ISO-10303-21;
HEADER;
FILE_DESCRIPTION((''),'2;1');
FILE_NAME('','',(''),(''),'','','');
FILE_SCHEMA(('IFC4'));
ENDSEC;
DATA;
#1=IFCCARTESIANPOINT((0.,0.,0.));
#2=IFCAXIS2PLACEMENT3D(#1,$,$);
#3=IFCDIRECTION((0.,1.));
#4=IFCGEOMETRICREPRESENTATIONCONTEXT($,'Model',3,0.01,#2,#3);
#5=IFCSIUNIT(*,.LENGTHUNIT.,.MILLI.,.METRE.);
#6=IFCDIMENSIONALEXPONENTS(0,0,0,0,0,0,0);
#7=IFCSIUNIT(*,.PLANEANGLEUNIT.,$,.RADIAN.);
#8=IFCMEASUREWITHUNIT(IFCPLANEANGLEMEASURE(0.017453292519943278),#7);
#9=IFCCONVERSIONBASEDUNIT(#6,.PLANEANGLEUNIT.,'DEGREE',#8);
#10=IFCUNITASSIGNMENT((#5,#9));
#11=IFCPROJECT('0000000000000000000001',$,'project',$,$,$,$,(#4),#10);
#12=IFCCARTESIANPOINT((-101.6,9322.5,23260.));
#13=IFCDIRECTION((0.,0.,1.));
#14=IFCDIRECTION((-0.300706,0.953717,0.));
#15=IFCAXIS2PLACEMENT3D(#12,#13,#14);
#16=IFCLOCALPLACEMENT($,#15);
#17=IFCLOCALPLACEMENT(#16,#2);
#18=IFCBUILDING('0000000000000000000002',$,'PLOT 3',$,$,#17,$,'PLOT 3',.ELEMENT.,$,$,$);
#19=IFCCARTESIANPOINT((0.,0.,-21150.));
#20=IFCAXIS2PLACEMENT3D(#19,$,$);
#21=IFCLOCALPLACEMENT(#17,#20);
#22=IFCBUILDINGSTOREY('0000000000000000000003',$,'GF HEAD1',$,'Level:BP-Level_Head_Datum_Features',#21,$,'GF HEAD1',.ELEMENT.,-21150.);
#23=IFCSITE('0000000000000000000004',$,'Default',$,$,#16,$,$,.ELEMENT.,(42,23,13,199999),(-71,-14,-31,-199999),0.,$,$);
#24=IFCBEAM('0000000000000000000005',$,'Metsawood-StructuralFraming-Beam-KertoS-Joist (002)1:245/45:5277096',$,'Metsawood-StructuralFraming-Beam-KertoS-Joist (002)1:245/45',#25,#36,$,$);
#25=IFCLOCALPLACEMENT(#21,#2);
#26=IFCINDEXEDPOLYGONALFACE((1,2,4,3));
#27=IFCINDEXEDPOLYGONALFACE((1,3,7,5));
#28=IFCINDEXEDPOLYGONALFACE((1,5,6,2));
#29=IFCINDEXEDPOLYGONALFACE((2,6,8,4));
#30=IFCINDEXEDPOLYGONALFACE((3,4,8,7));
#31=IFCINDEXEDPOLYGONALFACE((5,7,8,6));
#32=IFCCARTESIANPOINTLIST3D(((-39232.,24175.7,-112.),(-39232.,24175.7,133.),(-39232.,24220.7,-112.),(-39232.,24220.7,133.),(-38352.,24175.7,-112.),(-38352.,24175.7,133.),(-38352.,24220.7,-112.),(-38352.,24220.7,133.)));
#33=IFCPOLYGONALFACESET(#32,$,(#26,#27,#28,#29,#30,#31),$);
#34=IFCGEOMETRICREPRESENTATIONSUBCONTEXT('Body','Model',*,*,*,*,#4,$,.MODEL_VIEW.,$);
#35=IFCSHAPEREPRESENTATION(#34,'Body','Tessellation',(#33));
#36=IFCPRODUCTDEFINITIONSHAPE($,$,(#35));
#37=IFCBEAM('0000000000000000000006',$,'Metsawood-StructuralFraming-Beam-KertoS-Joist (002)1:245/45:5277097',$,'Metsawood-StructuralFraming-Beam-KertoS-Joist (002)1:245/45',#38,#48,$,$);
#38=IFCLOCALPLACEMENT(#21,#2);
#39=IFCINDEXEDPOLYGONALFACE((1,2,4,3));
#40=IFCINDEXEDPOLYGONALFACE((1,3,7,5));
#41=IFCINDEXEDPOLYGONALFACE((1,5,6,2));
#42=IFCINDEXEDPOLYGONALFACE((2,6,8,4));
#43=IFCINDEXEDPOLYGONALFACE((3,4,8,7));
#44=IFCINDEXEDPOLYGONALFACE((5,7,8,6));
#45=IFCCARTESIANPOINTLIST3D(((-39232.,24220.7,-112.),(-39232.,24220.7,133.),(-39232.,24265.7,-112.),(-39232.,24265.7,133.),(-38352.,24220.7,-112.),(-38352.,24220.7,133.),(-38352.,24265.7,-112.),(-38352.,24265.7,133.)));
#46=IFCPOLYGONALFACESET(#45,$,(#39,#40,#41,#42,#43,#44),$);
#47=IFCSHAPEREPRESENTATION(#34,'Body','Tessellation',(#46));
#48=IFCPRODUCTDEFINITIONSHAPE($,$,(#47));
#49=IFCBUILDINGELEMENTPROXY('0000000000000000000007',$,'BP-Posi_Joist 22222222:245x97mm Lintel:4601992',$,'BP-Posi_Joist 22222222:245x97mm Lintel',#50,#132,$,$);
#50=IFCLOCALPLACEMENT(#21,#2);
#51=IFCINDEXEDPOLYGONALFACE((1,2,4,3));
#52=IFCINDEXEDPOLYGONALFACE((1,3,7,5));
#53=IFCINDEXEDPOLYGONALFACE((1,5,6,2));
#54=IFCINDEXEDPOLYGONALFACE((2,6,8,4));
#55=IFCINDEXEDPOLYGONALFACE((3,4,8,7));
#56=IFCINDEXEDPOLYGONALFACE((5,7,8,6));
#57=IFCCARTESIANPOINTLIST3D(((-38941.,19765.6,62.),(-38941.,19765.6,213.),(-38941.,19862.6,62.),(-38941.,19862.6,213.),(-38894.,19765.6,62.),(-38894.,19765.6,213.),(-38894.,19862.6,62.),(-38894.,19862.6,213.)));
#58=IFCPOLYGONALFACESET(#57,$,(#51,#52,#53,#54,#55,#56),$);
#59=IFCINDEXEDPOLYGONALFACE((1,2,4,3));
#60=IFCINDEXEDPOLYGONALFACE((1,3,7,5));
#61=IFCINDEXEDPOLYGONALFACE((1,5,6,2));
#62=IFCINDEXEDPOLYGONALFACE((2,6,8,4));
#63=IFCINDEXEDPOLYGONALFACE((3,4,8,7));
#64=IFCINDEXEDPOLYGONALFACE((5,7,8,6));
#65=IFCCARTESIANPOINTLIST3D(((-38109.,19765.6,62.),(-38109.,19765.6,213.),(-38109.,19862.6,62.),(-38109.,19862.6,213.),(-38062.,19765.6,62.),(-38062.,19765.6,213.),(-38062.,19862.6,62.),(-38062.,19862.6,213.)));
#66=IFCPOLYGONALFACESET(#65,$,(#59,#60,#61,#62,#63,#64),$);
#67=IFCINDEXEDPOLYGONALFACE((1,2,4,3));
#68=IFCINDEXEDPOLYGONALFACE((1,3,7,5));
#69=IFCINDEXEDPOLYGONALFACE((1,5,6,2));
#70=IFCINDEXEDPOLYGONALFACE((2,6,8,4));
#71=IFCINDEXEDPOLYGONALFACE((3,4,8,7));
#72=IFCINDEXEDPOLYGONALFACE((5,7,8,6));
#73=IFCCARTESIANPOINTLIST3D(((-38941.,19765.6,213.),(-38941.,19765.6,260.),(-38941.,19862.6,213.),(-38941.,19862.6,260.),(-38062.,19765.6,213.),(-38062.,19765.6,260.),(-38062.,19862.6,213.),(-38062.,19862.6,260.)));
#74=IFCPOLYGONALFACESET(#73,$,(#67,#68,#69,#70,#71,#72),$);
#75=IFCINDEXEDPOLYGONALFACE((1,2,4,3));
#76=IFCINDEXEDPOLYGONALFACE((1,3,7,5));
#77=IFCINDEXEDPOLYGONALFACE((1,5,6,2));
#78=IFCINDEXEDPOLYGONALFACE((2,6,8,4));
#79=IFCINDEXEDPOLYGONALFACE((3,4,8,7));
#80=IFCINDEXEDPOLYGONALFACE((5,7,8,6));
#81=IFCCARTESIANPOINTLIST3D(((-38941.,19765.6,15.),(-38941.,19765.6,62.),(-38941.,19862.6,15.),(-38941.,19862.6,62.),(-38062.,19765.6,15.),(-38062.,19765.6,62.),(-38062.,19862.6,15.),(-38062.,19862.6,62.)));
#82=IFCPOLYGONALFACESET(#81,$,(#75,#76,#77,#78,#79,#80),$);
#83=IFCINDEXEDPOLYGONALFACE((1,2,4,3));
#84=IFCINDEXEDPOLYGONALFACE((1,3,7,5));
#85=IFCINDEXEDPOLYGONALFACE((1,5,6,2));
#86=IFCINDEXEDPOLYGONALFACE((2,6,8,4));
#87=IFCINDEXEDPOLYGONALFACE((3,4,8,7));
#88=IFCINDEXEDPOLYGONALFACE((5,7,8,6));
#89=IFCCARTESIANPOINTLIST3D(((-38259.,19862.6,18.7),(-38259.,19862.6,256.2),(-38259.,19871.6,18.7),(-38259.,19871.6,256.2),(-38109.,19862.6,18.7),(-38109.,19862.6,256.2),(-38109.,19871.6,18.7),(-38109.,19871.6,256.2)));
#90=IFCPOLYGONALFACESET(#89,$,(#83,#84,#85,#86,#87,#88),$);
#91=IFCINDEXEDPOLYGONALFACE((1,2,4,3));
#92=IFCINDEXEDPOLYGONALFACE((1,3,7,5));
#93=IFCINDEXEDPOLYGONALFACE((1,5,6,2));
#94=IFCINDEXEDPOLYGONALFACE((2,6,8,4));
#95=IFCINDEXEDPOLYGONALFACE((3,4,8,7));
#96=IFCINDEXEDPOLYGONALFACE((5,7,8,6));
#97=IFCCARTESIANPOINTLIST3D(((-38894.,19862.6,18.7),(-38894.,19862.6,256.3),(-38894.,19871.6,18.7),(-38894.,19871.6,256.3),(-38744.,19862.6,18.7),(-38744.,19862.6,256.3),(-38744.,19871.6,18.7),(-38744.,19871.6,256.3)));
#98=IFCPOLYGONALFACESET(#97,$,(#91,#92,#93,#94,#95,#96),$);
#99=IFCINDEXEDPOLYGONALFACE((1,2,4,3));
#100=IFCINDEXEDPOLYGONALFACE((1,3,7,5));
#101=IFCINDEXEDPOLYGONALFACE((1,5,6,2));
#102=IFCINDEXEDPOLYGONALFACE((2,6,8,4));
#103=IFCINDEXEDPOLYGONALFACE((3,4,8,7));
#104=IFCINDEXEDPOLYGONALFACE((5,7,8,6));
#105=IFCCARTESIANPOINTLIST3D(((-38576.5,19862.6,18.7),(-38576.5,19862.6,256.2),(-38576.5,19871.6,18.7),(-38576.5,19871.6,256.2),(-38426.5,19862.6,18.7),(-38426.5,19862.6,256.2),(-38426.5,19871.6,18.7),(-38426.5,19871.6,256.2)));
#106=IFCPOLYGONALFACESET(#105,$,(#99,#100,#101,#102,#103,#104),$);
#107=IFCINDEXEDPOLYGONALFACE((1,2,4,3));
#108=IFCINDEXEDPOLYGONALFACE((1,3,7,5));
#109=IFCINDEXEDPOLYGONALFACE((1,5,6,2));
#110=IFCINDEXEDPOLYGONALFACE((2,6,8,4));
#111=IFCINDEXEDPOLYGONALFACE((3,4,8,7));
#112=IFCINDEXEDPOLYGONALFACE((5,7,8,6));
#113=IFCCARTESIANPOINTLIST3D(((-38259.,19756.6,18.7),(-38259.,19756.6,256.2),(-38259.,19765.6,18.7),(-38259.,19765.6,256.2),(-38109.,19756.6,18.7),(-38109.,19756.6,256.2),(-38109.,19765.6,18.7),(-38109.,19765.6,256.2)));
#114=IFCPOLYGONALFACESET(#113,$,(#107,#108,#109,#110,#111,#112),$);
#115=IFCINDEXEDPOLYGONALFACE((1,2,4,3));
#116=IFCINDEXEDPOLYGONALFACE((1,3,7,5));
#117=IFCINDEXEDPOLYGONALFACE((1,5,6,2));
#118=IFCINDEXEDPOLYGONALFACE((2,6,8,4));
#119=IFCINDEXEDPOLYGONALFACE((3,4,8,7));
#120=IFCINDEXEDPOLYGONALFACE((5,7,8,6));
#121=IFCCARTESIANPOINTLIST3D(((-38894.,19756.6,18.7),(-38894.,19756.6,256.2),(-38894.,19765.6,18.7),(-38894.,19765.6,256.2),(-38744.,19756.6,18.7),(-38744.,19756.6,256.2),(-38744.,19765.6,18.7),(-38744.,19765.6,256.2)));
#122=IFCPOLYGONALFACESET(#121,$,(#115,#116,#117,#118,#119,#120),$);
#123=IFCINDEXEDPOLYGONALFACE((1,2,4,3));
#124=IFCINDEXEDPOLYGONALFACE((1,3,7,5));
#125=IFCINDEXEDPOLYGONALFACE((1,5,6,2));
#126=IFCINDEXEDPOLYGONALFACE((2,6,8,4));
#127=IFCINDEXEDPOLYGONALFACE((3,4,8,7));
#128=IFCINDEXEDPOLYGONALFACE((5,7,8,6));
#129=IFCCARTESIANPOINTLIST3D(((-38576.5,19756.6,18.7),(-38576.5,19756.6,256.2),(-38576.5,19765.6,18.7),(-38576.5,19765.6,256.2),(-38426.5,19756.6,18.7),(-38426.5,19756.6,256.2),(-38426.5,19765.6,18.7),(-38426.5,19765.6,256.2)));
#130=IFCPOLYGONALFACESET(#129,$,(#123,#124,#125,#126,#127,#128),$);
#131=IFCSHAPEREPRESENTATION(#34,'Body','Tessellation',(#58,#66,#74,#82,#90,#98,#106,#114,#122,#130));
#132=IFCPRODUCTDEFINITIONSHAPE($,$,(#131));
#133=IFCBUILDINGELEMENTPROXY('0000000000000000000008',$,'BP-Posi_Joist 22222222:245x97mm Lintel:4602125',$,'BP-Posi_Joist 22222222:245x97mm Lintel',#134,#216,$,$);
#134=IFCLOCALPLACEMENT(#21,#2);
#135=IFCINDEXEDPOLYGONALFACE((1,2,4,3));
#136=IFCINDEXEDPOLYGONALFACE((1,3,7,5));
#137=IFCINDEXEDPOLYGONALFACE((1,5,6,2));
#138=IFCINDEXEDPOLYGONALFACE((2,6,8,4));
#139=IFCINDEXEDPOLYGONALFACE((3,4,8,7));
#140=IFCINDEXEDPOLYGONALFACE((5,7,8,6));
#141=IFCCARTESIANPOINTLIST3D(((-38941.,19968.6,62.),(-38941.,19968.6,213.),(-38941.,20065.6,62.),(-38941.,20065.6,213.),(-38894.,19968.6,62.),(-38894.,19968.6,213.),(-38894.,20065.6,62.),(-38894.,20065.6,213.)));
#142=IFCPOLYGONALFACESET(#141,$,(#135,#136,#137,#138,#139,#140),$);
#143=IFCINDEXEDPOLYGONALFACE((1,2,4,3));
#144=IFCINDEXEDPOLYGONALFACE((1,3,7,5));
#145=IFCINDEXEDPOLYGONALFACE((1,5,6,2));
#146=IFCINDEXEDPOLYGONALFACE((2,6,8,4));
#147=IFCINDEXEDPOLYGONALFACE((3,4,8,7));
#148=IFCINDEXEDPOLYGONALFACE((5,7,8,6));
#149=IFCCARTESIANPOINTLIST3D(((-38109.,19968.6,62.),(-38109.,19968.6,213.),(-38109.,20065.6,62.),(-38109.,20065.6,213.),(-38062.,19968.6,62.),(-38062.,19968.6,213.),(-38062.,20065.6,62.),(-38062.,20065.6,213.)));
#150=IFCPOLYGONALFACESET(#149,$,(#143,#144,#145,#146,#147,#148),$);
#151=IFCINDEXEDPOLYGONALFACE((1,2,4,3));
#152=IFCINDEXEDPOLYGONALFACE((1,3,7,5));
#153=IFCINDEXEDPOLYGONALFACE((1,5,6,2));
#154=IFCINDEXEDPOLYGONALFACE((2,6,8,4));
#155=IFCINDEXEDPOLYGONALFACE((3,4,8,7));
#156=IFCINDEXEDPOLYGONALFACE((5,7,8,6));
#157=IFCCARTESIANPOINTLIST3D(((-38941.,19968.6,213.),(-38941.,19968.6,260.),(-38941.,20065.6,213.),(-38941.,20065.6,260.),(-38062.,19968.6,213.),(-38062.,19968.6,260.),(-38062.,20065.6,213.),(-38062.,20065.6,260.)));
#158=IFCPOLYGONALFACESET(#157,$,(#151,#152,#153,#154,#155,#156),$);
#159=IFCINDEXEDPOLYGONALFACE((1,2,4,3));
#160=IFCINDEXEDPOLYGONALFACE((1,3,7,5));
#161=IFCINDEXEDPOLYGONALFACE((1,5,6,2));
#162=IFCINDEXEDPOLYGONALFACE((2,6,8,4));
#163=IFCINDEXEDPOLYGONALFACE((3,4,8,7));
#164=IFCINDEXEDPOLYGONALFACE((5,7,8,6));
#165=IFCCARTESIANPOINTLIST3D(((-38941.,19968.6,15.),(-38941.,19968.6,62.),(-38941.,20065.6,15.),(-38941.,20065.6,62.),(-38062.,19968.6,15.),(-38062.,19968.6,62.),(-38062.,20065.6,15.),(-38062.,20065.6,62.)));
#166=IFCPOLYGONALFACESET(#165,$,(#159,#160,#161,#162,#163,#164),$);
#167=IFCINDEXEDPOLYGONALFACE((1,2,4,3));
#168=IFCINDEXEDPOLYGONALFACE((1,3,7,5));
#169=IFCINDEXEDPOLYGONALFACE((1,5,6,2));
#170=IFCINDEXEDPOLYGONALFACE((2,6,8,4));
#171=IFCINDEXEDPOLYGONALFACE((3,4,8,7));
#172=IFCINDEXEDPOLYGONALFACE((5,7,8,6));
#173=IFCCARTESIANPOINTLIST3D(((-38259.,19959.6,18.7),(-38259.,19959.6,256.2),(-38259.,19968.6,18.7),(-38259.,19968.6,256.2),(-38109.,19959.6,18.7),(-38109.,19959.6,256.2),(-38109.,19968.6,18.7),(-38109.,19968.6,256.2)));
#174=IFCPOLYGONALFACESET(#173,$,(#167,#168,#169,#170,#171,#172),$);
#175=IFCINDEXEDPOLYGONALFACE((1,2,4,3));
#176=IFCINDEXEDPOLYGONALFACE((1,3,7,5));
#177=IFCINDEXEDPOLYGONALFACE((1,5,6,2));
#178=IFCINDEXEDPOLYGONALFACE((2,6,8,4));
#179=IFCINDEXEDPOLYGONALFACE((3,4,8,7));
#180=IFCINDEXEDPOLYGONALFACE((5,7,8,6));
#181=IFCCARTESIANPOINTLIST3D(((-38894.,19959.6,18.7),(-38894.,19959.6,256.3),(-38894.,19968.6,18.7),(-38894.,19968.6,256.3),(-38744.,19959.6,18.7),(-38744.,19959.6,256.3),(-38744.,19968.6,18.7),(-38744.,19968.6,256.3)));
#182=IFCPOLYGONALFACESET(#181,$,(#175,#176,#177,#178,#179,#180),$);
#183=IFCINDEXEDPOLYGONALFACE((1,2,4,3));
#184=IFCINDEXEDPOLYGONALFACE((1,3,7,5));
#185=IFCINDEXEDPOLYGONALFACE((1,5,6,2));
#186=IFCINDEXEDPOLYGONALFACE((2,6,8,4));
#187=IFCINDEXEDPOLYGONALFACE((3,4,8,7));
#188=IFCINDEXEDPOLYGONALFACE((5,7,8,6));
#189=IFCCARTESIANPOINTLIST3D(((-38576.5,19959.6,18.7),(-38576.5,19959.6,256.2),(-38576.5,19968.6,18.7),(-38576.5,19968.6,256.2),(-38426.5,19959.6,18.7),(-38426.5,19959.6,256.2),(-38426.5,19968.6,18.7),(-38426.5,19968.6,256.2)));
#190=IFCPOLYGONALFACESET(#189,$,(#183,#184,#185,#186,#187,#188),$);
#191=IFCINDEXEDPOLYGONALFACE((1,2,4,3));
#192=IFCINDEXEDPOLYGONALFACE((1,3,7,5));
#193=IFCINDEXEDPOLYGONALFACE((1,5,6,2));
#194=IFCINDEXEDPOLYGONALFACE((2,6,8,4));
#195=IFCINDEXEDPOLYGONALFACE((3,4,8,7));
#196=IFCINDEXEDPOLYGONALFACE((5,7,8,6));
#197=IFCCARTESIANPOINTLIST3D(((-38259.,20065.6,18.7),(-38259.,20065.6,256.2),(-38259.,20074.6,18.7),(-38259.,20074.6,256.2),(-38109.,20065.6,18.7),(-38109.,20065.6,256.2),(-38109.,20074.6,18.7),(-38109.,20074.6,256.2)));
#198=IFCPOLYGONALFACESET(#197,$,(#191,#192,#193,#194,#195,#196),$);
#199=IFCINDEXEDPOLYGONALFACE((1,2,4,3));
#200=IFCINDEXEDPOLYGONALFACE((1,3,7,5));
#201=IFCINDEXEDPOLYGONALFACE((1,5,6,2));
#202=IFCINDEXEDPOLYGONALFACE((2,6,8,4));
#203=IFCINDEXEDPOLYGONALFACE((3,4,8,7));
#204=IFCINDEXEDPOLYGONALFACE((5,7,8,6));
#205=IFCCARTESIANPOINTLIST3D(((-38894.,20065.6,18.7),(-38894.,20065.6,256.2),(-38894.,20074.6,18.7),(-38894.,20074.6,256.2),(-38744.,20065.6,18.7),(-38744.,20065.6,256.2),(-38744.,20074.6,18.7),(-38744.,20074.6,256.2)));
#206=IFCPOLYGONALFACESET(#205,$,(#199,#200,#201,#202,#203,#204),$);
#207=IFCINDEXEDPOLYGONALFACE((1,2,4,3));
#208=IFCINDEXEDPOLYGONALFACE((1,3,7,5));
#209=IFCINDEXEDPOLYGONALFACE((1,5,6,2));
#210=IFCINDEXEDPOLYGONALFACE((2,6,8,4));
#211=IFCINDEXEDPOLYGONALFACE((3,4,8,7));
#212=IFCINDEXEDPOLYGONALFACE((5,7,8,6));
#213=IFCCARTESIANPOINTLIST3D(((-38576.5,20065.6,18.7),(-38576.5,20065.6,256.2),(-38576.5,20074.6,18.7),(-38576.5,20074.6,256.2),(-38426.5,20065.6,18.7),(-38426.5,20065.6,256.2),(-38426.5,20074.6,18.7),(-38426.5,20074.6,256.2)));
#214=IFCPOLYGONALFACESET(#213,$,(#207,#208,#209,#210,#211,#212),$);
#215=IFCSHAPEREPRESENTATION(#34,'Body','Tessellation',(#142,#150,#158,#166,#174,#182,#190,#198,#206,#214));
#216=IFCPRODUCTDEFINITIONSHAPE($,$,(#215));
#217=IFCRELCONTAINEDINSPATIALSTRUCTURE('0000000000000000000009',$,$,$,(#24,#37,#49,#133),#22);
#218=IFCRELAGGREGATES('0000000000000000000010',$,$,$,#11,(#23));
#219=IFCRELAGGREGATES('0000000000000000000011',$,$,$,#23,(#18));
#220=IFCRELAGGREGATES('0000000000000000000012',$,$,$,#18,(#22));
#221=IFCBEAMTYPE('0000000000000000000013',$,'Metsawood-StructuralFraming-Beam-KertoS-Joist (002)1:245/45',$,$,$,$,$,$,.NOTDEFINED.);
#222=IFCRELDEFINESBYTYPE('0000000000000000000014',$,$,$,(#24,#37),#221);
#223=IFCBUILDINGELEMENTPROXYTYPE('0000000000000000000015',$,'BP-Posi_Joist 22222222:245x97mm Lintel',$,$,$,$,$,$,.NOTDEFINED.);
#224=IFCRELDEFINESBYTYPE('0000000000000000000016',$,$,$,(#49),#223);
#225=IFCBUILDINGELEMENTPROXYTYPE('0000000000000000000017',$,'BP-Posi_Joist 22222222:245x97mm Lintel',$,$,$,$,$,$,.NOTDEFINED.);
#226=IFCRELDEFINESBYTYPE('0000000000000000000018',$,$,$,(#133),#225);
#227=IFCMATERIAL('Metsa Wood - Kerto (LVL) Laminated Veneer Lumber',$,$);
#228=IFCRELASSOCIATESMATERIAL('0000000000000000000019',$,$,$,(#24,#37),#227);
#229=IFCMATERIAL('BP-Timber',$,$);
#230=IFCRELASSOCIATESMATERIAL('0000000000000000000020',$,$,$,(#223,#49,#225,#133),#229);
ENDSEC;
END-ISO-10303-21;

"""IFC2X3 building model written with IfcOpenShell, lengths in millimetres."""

from ifc_helpers import new_model, entity, si_unit, converted_unit, direction, frame, frame_2d, origin, origin_2d_with_axis, place, context, subcontext, project, spatial, rectangle, extrude, source, transform, mapped, material, type_object, type_shapes, element, save


model = new_model("IFC2X3")

# Units and contexts
model_context = context("Model", 3, precision=0.01, world=origin(), true_north=direction((0.0, 1.0)))
body_context = subcontext(model_context, "Body", "Model", "MODEL_VIEW")
ifc_project = project(units=[si_unit("LENGTHUNIT", "METRE", prefix="MILLI"), converted_unit("PLANEANGLEUNIT", "DEGREE", entity("IfcPlaneAngleMeasure", 0.017453292519943278), si_unit("PLANEANGLEUNIT", "RADIAN"), dimensions=[0, 0, 0, 0, 0, 0, 0])], contexts=[model_context])

# Site, building, storey
site_placement = place(None, frame((-101.6, 9322.5, 23260.0), z_axis=(0.0, 0.0, 1.0), x_axis=(-0.300706, 0.953717, 0.0)))
site = spatial("IfcSite", under=ifc_project, at=site_placement, Name="Default", CompositionType="ELEMENT", RefLatitude=(42, 23, 13, 199999), RefLongitude=(-71, -14, -31, -199999), RefElevation=0.0)
building_placement = place(site_placement, origin())
building = spatial("IfcBuilding", under=site, at=building_placement, Name="PLOT 3", LongName="PLOT 3", CompositionType="ELEMENT")
storey_placement = place(building_placement, frame((0.0, 0.0, -21150.0)))
storey = spatial("IfcBuildingStorey", under=building, at=storey_placement, Name="GF HEAD1", ObjectType="Level:BP-Level_Head_Datum_Features", LongName="GF HEAD1", CompositionType="ELEMENT", Elevation=-21150.0)

# Shared definitions
ifc_material_1 = material(Name="BP-Timber")

# Beams
ifc_material_2 = material(Name="Metsa Wood - Kerto (LVL) Laminated Veneer Lumber")
beam_type_1 = type_object("IfcBeamType", Name="Metsawood-StructuralFraming-Beam-KertoS-Joist (002)1:245/45", PredefinedType="NOTDEFINED")
beam_1_placement = place(storey_placement, frame((-39232.0, 24198.2, 10.5)))
element("IfcBeam", 1, at=beam_1_placement, inside=storey, type_object=beam_type_1, material=ifc_material_2, Name="Metsawood-StructuralFraming-Beam-KertoS-Joist (002)1:245/45:5277096", ObjectType="Metsawood-StructuralFraming-Beam-KertoS-Joist (002)1:245/45", context=body_context, shape_type="SweptSolid", body=[
    extrude(rectangle(XDim=245.0, YDim=45.0, at=frame_2d((0.0, 0.0), x_axis=(1.0, 0.0))), frame((0.0, 0.0, 0.0), z_axis=(1.0, 0.0, 0.0), x_axis=(0.0, 0.0, -1.0)), (0.0, 0.0, 1.0), 880.0),
])
beam_2_placement = place(storey_placement, frame((-39232.0, 24243.2, 10.5)))
element("IfcBeam", 2, at=beam_2_placement, inside=storey, type_object=beam_type_1, material=ifc_material_2, Name="Metsawood-StructuralFraming-Beam-KertoS-Joist (002)1:245/45:5277097", ObjectType="Metsawood-StructuralFraming-Beam-KertoS-Joist (002)1:245/45", context=body_context, shape_type="SweptSolid", body=[
    extrude(rectangle(XDim=245.0, YDim=45.0, at=frame_2d((0.0, 0.0), x_axis=(1.0, 0.0))), frame((0.0, 0.0, 0.0), z_axis=(1.0, 0.0, 0.0), x_axis=(0.0, 0.0, -1.0)), (0.0, 0.0, 1.0), 880.0),
])

# Building element proxies
building_element_proxy_type_1 = type_object("IfcBuildingElementProxyType", Name="BP-Posi_Joist 22222222:245x97mm Lintel", PredefinedType="NOTDEFINED", material=ifc_material_1)
shared_shape_1 = source(origin(), body_context, "Body", "SweptSolid", [
    extrude(rectangle(XDim=47.0, YDim=97.0, at=origin_2d_with_axis()), frame((320.4, 0.0, -198.0), z_axis=(0.0, 0.0, 1.0), x_axis=(-1.0, 0.0, 0.0)), (0.0, 0.0, 1.0), 151.0),
    extrude(rectangle(XDim=47.0, YDim=97.0, at=frame_2d((0.0, 0.0), x_axis=(1.0, 0.0))), frame((1152.4, 0.0, -198.0), z_axis=(0.0, 0.0, 1.0), x_axis=(-1.0, 0.0, 0.0)), (0.0, 0.0, 1.0), 151.0),
    extrude(rectangle(XDim=97.0, YDim=879.0, at=frame_2d((0.0, 0.0), x_axis=(1.0, 0.0))), frame((736.4, 0.0, -47.0), z_axis=(0.0, 0.0, 1.0), x_axis=(0.0, -1.0, 0.0)), (0.0, 0.0, 1.0), 47.0),
    extrude(rectangle(XDim=97.0, YDim=879.0, at=frame_2d((0.0, 0.0), x_axis=(1.0, 0.0))), frame((736.4, 0.0, -245.0), z_axis=(0.0, 0.0, 1.0), x_axis=(0.0, -1.0, 0.0)), (0.0, 0.0, 1.0), 47.0),
    extrude(rectangle(XDim=9.0, YDim=150.0, at=origin_2d_with_axis()), frame((1053.9, 53.0, -241.3), z_axis=(0.0, 0.0, 1.0), x_axis=(0.0, -1.0, 0.0)), (0.0, 0.0, 1.0), 237.5),
    extrude(rectangle(XDim=9.0, YDim=150.0, at=frame_2d((0.0, 0.0), x_axis=(1.0, 0.0))), frame((418.9, 53.0, -241.3), z_axis=(0.0, 0.0, 1.0), x_axis=(0.0, 1.0, 0.0)), (0.0, 0.0, 1.0), 237.5),
    extrude(rectangle(XDim=9.0, YDim=150.0, at=origin_2d_with_axis()), frame((736.4, 53.0, -241.3), z_axis=(0.0, 0.0, 1.0), x_axis=(0.0, -1.0, 0.0)), (0.0, 0.0, 1.0), 237.5),
    extrude(rectangle(XDim=9.0, YDim=150.0, at=origin_2d_with_axis()), frame((1053.9, -53.0, -241.3), z_axis=(0.0, 0.0, 1.0), x_axis=(0.0, -1.0, 0.0)), (0.0, 0.0, 1.0), 237.5),
    extrude(rectangle(XDim=9.0, YDim=150.0, at=frame_2d((0.0, 0.0), x_axis=(1.0, 0.0))), frame((418.9, -53.0, -241.3), z_axis=(0.0, 0.0, 1.0), x_axis=(0.0, 1.0, 0.0)), (0.0, 0.0, 1.0), 237.5),
    extrude(rectangle(XDim=9.0, YDim=150.0, at=origin_2d_with_axis()), frame((736.4, -53.0, -241.3), z_axis=(0.0, 0.0, 1.0), x_axis=(0.0, -1.0, 0.0)), (0.0, 0.0, 1.0), 237.5),
])
type_shapes(building_element_proxy_type_1, [shared_shape_1])
proxy_1_placement = place(storey_placement, frame((-39237.9, 19814.1, 260.0)))
element("IfcBuildingElementProxy", 3, at=proxy_1_placement, inside=storey, type_object=building_element_proxy_type_1, material=ifc_material_1, Name="BP-Posi_Joist 22222222:245x97mm Lintel:4601992", ObjectType="BP-Posi_Joist 22222222:245x97mm Lintel", context=body_context, shape_type="MappedRepresentation", body=[
    mapped(shared_shape_1, transform((0.0, 0.0, 0.0), scale=1.0)),
])
building_element_proxy_type_2 = type_object("IfcBuildingElementProxyType", Name="BP-Posi_Joist 22222222:245x97mm Lintel", PredefinedType="NOTDEFINED", material=ifc_material_1)
shared_shape_2 = source(origin(), body_context, "Body", "SweptSolid", [
    extrude(rectangle(XDim=97.0, YDim=47.0, at=origin_2d_with_axis()), frame((320.4, 0.0, -198.0), z_axis=(0.0, 0.0, 1.0), x_axis=(0.0, 1.0, 0.0)), (0.0, 0.0, 1.0), 151.0),
    extrude(rectangle(XDim=97.0, YDim=47.0, at=origin_2d_with_axis()), frame((1152.4, 0.0, -198.0), z_axis=(0.0, 0.0, 1.0), x_axis=(0.0, 1.0, 0.0)), (0.0, 0.0, 1.0), 151.0),
    extrude(rectangle(XDim=879.0, YDim=97.0, at=frame_2d((0.0, 0.0), x_axis=(1.0, 0.0))), frame((736.4, 0.0, -47.0)), (0.0, 0.0, 1.0), 47.0),
    extrude(rectangle(XDim=879.0, YDim=97.0, at=frame_2d((0.0, 0.0), x_axis=(1.0, 0.0))), frame((736.4, 0.0, -245.0)), (0.0, 0.0, 1.0), 47.0),
    extrude(rectangle(XDim=150.0, YDim=9.0, at=origin_2d_with_axis()), frame((1053.9, -53.0, -241.3)), (0.0, 0.0, 1.0), 237.5),
    extrude(rectangle(XDim=150.0, YDim=9.0, at=frame_2d((0.0, 0.0), x_axis=(1.0, 0.0))), frame((418.9, -53.0, -241.3), z_axis=(0.0, 0.0, 1.0), x_axis=(-1.0, 0.0, 0.0)), (0.0, 0.0, 1.0), 237.5),
    extrude(rectangle(XDim=150.0, YDim=9.0, at=origin_2d_with_axis()), frame((736.4, -53.0, -241.3)), (0.0, 0.0, 1.0), 237.5),
    extrude(rectangle(XDim=150.0, YDim=9.0, at=origin_2d_with_axis()), frame((1053.9, 53.0, -241.3)), (0.0, 0.0, 1.0), 237.5),
    extrude(rectangle(XDim=150.0, YDim=9.0, at=frame_2d((0.0, 0.0), x_axis=(1.0, 0.0))), frame((418.9, 53.0, -241.3), z_axis=(0.0, 0.0, 1.0), x_axis=(-1.0, 0.0, 0.0)), (0.0, 0.0, 1.0), 237.5),
    extrude(rectangle(XDim=150.0, YDim=9.0, at=origin_2d_with_axis()), frame((736.4, 53.0, -241.3)), (0.0, 0.0, 1.0), 237.5),
])
type_shapes(building_element_proxy_type_2, [shared_shape_2])
proxy_2_placement = place(storey_placement, frame((-39237.9, 20017.1, 260.0)))
element("IfcBuildingElementProxy", 4, at=proxy_2_placement, inside=storey, type_object=building_element_proxy_type_2, material=ifc_material_1, Name="BP-Posi_Joist 22222222:245x97mm Lintel:4602125", ObjectType="BP-Posi_Joist 22222222:245x97mm Lintel", context=body_context, shape_type="MappedRepresentation", body=[
    mapped(shared_shape_2, transform((0.0, 0.0, 0.0), scale=1.0)),
])

save(model, "model.ifc")
